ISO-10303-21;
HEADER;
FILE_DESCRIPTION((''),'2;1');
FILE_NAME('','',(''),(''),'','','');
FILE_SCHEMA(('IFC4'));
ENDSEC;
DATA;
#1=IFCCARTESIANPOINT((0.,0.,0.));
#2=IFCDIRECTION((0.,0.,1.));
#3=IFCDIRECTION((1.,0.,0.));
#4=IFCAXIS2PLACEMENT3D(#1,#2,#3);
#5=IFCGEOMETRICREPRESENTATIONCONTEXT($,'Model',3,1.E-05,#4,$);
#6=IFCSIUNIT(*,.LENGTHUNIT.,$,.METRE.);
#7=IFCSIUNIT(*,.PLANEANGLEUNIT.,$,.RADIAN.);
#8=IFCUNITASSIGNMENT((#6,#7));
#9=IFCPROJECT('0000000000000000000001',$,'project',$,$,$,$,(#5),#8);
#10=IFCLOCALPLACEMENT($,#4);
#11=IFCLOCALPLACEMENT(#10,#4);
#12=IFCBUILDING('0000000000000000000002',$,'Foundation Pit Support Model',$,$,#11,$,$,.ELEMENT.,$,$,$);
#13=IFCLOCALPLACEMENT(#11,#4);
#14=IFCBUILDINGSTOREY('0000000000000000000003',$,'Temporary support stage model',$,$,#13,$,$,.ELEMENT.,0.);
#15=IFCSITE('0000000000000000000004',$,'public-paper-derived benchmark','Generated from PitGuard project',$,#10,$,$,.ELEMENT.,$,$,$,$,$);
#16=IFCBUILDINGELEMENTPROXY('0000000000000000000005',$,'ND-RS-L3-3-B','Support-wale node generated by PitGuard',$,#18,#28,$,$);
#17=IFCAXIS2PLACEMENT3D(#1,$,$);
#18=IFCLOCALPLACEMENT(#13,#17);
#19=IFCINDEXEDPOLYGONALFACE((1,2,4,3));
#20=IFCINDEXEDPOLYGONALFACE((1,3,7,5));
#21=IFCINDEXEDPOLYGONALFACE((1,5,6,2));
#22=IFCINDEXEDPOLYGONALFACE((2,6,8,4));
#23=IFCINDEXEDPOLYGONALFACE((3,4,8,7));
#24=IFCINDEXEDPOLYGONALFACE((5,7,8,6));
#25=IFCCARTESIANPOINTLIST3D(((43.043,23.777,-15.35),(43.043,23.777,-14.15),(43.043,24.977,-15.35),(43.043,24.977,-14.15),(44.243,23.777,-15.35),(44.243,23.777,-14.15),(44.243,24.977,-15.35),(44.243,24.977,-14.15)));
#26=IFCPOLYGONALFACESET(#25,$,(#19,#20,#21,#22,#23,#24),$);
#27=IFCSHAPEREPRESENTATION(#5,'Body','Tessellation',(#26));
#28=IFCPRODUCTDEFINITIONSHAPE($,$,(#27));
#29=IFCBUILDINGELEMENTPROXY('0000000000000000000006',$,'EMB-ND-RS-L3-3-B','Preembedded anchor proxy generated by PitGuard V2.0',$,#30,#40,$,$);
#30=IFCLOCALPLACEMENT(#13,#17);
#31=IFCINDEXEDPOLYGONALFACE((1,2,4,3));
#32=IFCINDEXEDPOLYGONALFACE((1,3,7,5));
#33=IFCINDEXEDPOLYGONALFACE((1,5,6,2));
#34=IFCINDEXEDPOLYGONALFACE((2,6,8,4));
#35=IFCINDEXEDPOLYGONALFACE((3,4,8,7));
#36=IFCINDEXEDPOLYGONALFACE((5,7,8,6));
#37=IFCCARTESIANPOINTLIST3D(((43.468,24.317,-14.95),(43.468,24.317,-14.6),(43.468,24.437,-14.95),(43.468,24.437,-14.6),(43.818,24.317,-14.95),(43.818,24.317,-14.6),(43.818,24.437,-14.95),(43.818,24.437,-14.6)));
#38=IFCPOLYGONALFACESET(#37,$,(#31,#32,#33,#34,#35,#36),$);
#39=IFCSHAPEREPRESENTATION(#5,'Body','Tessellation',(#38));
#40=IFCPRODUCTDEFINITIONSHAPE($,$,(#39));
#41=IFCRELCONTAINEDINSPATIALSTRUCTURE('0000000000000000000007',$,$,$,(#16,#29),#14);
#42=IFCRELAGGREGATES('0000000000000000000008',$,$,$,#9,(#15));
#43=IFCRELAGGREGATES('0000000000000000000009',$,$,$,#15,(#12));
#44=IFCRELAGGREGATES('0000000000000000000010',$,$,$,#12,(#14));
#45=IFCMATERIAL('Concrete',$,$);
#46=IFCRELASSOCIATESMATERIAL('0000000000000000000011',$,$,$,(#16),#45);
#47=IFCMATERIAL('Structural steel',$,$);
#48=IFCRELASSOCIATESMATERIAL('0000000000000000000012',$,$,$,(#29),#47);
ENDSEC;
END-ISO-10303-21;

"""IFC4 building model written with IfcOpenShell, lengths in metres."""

from ifc_helpers import new_model, si_unit, frame, origin_with_axes, origin_2d, place, context, project, spatial, rectangle, extrude, material, element, save


model = new_model("IFC4")

# Units and contexts
model_context = context("Model", 3, precision=1e-05, world=origin_with_axes())
ifc_project = project(units=[si_unit("LENGTHUNIT", "METRE"), si_unit("PLANEANGLEUNIT", "RADIAN")], contexts=[model_context])

# Site, building, storey
site_placement = place(None, origin_with_axes())
site = spatial("IfcSite", under=ifc_project, at=site_placement, Name="public-paper-derived benchmark", Description="Generated from PitGuard project", CompositionType="ELEMENT")
building_placement = place(site_placement, origin_with_axes())
building = spatial("IfcBuilding", under=site, at=building_placement, Name="Foundation Pit Support Model", CompositionType="ELEMENT")
storey_placement = place(building_placement, origin_with_axes())
storey = spatial("IfcBuildingStorey", under=building, at=storey_placement, Name="Temporary support stage model", CompositionType="ELEMENT", Elevation=0.0)

# Shared definitions
ifc_material_1 = material(Name="Concrete")

# Shared definitions
ifc_material_2 = material(Name="Structural steel")

# Building element proxies
proxy_1_placement = place(storey_placement, frame((43.643, 24.377, -15.35), z_axis=(0.0, 0.0, 1.0), x_axis=(1.0, 0.0, 0.0)))
element("IfcBuildingElementProxy", 1, at=proxy_1_placement, inside=storey, material=ifc_material_1, Name="ND-RS-L3-3-B", Description="Support-wale node generated by PitGuard", context=model_context, shape_type="SweptSolid", body=[
    extrude(rectangle(XDim=1.2, YDim=1.2, at=origin_2d()), origin_with_axes(), (0.0, 0.0, 1.0), 1.2),
])
proxy_2_placement = place(storey_placement, frame((43.643, 24.377, -14.95), z_axis=(0.0, 0.0, 1.0), x_axis=(1.0, 0.0, 0.0)))
element("IfcBuildingElementProxy", 2, at=proxy_2_placement, inside=storey, material=ifc_material_2, Name="EMB-ND-RS-L3-3-B", Description="Preembedded anchor proxy generated by PitGuard V2.0", context=model_context, shape_type="SweptSolid", body=[
    extrude(rectangle(XDim=0.35, YDim=0.12, at=origin_2d()), origin_with_axes(), (0.0, 0.0, 1.0), 0.35),
])

save(model, "model.ifc")
